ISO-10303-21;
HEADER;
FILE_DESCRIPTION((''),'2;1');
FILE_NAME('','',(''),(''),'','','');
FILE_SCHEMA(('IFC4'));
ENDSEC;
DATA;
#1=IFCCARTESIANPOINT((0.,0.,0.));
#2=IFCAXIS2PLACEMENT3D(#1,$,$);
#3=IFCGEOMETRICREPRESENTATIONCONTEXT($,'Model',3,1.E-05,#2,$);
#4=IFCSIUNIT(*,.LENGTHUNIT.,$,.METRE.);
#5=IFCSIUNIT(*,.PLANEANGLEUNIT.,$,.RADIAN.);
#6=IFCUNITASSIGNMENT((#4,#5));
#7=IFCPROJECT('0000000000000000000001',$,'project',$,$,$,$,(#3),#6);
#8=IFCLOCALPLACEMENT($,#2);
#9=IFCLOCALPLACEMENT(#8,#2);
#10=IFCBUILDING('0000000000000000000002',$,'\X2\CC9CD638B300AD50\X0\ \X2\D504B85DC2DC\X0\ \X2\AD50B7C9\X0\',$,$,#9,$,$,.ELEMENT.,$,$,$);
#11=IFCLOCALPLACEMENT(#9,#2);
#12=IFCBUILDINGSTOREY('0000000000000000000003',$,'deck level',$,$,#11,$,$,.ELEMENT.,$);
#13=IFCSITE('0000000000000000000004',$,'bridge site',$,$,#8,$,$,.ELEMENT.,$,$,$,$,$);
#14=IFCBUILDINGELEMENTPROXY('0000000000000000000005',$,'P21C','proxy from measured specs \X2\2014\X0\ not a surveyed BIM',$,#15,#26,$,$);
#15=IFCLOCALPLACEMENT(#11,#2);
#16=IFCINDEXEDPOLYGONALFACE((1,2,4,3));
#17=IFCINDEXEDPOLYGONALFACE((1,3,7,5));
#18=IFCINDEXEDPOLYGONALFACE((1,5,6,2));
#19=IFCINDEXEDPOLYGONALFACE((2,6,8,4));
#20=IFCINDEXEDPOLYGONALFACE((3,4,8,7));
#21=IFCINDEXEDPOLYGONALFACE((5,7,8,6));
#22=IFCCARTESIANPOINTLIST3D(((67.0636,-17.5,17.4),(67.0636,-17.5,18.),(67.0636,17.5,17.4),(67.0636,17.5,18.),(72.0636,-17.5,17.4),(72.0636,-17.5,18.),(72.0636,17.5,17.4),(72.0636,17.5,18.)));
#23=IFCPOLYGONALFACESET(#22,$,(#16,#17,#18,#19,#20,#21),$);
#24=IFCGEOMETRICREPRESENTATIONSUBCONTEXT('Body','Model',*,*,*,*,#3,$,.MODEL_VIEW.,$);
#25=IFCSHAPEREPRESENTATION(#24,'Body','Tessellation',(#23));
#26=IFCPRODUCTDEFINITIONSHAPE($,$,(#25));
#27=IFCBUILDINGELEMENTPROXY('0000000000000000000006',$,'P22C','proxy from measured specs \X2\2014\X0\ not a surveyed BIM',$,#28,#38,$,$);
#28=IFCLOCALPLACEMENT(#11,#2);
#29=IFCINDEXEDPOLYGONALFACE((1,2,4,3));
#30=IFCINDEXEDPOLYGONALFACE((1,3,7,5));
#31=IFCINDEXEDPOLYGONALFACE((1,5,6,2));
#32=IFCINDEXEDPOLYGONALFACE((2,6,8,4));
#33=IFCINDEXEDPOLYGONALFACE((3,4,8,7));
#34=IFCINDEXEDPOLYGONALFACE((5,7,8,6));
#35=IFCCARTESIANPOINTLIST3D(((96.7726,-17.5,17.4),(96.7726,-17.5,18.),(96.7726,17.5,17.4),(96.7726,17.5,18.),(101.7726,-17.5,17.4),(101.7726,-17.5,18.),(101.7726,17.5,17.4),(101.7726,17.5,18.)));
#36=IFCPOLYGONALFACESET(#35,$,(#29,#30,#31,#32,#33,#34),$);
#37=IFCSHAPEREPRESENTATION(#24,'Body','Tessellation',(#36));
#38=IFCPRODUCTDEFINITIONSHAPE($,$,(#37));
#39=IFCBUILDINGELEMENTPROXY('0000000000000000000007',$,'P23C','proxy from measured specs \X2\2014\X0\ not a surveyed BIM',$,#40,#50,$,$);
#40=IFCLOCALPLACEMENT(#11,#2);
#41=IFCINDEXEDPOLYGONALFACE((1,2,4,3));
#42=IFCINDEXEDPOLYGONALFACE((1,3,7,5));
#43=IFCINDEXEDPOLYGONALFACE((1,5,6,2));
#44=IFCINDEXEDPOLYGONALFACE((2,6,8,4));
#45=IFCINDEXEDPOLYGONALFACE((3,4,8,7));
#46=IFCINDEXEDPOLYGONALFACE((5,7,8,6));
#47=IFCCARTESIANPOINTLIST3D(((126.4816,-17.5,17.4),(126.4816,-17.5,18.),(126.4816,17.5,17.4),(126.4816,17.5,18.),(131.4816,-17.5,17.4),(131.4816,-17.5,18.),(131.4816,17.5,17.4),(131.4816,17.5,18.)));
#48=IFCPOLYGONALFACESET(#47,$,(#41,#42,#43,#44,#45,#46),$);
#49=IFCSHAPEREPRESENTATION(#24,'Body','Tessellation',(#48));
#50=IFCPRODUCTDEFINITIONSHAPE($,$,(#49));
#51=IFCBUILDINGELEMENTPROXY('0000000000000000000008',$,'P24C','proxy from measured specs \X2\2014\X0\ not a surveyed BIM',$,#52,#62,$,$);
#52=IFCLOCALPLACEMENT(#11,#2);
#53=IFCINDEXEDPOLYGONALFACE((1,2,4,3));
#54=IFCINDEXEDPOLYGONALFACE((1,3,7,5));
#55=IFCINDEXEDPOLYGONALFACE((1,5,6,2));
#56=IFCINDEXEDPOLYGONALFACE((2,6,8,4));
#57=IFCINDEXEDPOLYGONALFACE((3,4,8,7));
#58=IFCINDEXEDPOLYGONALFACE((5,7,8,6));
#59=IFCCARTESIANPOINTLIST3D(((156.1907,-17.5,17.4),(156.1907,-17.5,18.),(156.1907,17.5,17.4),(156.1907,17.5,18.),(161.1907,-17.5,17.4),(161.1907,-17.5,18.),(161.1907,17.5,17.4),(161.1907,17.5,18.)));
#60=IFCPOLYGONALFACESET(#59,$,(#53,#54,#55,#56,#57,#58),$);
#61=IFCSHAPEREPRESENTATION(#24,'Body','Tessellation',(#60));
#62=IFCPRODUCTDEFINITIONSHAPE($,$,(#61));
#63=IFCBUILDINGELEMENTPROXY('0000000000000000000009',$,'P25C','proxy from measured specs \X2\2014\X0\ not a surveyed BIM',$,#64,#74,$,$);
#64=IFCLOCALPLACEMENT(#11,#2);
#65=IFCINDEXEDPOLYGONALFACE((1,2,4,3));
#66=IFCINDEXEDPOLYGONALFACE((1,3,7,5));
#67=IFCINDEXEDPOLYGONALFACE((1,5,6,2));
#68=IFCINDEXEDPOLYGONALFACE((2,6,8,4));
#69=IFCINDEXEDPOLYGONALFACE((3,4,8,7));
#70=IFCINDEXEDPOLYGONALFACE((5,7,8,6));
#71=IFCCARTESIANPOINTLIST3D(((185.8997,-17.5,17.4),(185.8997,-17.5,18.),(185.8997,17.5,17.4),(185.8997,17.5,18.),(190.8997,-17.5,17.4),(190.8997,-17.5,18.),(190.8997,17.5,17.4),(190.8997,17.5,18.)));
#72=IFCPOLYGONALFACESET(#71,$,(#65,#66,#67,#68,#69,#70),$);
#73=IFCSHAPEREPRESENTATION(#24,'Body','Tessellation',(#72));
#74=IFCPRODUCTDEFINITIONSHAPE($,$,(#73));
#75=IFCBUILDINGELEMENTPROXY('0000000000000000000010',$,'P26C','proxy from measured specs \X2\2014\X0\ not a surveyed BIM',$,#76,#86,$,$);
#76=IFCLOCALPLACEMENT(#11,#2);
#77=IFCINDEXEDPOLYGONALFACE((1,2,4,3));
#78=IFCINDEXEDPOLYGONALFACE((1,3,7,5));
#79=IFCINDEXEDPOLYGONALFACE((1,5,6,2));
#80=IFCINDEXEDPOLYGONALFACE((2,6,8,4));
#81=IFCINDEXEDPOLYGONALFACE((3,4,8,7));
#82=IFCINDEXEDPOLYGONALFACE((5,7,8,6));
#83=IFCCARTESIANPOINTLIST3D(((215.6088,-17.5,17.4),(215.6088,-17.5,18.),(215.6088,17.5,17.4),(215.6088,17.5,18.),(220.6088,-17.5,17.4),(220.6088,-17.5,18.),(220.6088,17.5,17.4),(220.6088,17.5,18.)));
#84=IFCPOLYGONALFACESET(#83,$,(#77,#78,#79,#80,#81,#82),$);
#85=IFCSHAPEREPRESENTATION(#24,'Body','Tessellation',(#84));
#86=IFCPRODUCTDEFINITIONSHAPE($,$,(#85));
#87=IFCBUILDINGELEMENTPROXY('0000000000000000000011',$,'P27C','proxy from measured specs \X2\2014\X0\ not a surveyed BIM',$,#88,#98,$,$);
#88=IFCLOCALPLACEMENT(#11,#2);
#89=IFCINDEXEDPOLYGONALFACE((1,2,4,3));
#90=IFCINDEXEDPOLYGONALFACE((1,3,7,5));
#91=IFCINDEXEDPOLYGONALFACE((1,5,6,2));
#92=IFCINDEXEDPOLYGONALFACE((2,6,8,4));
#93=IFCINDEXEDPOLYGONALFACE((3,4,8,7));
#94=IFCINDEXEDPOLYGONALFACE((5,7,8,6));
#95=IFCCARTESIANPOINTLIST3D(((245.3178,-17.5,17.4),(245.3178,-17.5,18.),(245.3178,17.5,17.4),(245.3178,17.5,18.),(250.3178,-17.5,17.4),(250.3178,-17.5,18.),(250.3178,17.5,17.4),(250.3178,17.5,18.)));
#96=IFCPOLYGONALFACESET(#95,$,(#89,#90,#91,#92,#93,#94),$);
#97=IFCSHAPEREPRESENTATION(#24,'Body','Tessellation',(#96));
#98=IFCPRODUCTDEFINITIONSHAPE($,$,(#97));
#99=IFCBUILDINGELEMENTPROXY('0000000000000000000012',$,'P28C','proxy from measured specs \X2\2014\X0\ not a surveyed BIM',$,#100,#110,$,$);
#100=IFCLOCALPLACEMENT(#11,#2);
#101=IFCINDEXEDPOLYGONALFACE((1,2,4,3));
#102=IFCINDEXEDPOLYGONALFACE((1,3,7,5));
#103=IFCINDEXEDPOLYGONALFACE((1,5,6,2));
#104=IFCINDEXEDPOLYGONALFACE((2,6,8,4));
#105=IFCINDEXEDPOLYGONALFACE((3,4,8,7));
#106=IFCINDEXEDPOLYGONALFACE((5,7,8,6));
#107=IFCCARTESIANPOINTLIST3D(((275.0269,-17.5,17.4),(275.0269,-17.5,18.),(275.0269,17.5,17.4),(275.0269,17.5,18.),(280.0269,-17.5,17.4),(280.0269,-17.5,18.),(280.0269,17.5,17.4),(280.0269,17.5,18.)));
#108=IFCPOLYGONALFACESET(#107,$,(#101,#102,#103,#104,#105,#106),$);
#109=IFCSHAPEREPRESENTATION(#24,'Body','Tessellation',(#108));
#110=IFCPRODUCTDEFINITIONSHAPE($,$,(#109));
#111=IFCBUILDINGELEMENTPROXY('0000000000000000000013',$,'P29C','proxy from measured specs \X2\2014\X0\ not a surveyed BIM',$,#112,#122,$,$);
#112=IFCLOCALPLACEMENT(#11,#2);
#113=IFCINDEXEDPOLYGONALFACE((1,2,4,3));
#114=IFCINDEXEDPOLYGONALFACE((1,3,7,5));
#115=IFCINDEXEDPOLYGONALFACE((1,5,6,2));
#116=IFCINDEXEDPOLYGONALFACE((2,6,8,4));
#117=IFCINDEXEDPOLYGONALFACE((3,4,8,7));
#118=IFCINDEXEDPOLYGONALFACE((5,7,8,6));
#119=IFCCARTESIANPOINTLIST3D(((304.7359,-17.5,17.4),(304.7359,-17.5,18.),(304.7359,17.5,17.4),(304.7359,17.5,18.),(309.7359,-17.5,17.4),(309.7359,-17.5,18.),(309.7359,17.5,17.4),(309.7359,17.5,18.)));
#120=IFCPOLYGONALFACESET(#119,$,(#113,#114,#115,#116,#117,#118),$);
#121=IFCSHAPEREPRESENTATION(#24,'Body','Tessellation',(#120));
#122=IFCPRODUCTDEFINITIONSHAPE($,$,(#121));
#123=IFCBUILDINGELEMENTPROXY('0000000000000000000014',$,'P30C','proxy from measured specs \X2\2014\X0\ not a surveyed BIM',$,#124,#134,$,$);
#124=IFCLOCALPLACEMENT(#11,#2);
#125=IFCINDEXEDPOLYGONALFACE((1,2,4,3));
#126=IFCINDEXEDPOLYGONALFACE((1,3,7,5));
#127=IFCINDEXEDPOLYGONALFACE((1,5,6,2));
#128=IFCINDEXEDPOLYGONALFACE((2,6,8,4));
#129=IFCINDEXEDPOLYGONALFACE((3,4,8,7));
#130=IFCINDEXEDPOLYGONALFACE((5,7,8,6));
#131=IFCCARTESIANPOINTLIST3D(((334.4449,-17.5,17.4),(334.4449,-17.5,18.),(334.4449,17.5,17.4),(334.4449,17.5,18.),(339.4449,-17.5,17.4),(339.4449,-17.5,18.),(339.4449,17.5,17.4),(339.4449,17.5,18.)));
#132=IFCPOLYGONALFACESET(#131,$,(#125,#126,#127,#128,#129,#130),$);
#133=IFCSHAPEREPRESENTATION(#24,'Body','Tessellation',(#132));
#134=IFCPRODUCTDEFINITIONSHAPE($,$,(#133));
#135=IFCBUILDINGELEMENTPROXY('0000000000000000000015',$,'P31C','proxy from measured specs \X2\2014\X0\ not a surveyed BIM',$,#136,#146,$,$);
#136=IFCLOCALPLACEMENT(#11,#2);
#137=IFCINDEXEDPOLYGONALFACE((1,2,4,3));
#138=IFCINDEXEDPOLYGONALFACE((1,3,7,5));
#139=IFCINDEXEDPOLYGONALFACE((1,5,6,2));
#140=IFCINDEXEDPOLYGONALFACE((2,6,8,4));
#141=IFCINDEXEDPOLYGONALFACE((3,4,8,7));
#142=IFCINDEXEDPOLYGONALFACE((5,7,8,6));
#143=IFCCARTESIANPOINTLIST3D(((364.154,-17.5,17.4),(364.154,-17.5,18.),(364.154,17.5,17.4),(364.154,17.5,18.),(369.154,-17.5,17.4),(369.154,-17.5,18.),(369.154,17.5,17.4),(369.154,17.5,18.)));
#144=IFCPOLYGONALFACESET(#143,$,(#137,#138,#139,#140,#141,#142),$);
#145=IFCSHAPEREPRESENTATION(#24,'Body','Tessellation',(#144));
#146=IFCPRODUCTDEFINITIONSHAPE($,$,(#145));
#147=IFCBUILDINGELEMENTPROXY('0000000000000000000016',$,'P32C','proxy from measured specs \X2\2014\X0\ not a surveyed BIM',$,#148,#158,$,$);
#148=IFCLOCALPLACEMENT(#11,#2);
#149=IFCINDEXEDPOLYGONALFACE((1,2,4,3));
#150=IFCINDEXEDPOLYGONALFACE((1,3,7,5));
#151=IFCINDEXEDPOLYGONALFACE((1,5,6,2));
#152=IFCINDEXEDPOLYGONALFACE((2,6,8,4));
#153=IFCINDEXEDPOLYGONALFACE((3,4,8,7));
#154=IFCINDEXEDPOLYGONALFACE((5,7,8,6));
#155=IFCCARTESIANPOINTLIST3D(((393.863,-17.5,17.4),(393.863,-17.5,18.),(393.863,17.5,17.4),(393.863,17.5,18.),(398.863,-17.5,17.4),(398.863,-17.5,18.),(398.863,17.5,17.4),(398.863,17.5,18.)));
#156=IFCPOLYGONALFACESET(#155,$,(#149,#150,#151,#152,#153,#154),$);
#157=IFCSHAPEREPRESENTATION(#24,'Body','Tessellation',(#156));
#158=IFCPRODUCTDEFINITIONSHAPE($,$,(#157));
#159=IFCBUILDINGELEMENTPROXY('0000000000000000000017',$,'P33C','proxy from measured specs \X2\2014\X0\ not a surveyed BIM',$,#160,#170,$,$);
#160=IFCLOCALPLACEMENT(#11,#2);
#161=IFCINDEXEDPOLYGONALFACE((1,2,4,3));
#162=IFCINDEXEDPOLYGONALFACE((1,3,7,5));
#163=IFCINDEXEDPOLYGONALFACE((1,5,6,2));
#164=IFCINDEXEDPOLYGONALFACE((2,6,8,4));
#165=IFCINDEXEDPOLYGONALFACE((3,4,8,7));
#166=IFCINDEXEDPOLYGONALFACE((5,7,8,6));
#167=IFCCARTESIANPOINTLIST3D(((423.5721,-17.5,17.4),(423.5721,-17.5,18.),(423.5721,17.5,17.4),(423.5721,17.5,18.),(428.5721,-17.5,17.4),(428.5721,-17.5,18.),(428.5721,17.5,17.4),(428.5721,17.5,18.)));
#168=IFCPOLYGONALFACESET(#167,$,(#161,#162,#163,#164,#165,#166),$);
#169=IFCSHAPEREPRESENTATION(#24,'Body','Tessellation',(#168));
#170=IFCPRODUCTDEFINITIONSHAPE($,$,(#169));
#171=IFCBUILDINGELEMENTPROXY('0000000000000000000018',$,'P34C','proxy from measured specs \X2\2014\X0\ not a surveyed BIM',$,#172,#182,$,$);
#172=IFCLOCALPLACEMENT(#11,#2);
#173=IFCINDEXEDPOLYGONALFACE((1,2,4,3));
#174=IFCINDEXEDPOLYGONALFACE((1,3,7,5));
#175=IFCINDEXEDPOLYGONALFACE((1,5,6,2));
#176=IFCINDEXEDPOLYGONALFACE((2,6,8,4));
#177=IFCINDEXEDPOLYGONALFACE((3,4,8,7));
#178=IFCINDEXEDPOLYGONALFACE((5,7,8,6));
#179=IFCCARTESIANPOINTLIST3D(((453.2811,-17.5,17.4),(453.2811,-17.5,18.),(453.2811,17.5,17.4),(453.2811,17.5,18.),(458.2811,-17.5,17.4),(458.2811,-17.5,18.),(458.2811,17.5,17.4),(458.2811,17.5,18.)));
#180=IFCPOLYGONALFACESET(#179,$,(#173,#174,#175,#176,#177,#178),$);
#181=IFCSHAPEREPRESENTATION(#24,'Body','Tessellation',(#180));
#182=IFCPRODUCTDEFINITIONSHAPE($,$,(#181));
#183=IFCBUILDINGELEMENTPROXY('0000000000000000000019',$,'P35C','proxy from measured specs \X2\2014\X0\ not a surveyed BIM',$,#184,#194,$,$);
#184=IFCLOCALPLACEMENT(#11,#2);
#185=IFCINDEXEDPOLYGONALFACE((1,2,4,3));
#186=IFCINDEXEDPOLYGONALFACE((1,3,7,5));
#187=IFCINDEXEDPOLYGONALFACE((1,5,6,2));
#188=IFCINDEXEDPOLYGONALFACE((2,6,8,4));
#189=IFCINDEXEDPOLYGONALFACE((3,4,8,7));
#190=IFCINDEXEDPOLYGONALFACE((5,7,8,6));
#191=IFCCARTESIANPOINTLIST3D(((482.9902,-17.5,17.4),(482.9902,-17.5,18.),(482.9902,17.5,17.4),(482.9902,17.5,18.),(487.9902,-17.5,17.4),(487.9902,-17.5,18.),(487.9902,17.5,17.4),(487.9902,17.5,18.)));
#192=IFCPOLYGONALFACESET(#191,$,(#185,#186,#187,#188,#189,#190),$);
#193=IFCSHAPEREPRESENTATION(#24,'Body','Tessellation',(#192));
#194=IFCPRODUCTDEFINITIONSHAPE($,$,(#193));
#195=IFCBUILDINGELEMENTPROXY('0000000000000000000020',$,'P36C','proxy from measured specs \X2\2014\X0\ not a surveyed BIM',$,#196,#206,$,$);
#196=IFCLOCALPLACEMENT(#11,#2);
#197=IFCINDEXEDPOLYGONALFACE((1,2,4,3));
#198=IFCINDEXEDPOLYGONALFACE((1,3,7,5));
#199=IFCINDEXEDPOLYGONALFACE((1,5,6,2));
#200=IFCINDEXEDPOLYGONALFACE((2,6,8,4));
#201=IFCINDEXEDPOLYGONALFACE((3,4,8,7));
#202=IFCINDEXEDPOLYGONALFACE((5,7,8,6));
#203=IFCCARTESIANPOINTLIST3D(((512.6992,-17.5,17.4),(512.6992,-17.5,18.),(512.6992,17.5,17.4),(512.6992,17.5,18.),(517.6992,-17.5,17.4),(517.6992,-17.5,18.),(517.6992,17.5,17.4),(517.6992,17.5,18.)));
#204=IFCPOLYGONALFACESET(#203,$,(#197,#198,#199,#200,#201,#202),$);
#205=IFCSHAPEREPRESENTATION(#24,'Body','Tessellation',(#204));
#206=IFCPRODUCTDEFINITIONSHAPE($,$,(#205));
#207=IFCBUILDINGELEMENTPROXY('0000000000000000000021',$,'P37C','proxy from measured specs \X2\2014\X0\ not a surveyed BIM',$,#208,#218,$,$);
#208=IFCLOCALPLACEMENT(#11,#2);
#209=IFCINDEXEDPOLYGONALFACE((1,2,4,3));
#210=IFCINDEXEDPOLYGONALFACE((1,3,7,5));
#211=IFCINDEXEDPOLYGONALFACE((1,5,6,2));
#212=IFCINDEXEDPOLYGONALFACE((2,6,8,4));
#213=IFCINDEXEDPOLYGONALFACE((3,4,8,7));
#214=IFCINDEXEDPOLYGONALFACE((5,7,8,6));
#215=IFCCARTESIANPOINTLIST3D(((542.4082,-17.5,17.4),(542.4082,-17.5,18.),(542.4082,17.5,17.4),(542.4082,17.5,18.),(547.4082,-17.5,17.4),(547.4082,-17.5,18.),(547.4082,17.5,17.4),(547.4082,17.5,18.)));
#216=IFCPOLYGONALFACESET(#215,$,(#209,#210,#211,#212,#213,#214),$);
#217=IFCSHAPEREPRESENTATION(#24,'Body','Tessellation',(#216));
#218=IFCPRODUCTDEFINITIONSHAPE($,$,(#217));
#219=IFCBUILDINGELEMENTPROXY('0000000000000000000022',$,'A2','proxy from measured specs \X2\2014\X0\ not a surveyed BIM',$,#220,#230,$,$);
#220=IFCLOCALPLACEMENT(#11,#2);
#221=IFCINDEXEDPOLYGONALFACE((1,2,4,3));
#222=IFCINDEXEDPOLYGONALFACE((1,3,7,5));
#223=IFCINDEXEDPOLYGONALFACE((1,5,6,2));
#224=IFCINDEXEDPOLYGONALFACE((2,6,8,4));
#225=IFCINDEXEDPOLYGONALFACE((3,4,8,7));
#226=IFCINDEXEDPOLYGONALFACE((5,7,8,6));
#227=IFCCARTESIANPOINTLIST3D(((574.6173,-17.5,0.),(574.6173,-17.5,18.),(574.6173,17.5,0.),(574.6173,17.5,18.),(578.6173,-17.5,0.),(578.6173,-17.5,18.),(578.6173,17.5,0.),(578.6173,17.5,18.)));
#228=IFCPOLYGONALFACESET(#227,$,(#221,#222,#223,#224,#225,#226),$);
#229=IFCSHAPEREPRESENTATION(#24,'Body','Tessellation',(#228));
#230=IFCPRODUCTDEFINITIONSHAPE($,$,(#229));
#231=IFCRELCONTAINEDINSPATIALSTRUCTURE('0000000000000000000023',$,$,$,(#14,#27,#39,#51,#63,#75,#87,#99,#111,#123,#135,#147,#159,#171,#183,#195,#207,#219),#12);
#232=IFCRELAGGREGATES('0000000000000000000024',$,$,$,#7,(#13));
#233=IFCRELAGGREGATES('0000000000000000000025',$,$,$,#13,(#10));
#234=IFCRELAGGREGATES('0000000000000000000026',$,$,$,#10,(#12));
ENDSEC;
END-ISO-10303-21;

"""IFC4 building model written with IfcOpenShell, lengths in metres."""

from ifc_helpers import new_model, si_unit, frame, origin, origin_2d, place, context, subcontext, project, spatial, rectangle, extrude, element, save


model = new_model("IFC4")

# Units and contexts
model_context = context("Model", 3, precision=1e-05, world=origin())
body_context = subcontext(model_context, "Body", "Model", "MODEL_VIEW")
ifc_project = project(units=[si_unit("LENGTHUNIT", "METRE"), si_unit("PLANEANGLEUNIT", "RADIAN")], contexts=[model_context])

# Site, building, storey
site_placement = place(None, origin())
site = spatial("IfcSite", under=ifc_project, at=site_placement, Name="bridge site", CompositionType="ELEMENT")
building_placement = place(site_placement, origin())
building = spatial("IfcBuilding", under=site, at=building_placement, Name="천호대교 프록시 교량", CompositionType="ELEMENT")
storey_placement = place(building_placement, origin())
storey = spatial("IfcBuildingStorey", under=building, at=storey_placement, Name="deck level", CompositionType="ELEMENT")

# Building element proxies
for number, where, name in (
    (1, (69.5636, 0.0, 17.4), "P21C"),
    (2, (99.2726, 0.0, 17.4), "P22C"),
    (3, (128.9816, 0.0, 17.4), "P23C"),
    (4, (158.6907, 0.0, 17.4), "P24C"),
    (5, (188.3997, 0.0, 17.4), "P25C"),
    (6, (218.1088, 0.0, 17.4), "P26C"),
    (7, (247.8178, 0.0, 17.4), "P27C"),
    (8, (277.5269, 0.0, 17.4), "P28C"),
    (9, (307.2359, 0.0, 17.4), "P29C"),
    (10, (336.9449, 0.0, 17.4), "P30C"),
    (11, (366.654, 0.0, 17.4), "P31C"),
    (12, (396.363, 0.0, 17.4), "P32C"),
    (13, (426.0721, 0.0, 17.4), "P33C"),
    (14, (455.7811, 0.0, 17.4), "P34C"),
    (15, (485.4902, 0.0, 17.4), "P35C"),
    (16, (515.1992, 0.0, 17.4), "P36C"),
    (17, (544.9082, 0.0, 17.4), "P37C"),
):
    element("IfcBuildingElementProxy", number, at=place(storey_placement, frame(where)), inside=storey, Name=name, Description="proxy from measured specs — not a surveyed BIM", context=body_context, shape_type="SweptSolid", body=[
        extrude(rectangle(XDim=5.0, YDim=35.0, at=origin_2d()), origin(), (0.0, 0.0, 1.0), 0.6),
    ])
proxy_placement = place(storey_placement, frame((576.6173, 0.0, 0.0)))
element("IfcBuildingElementProxy", 18, at=proxy_placement, inside=storey, Name="A2", Description="proxy from measured specs — not a surveyed BIM", context=body_context, shape_type="SweptSolid", body=[
    extrude(rectangle(XDim=4.0, YDim=35.0, at=origin_2d()), origin(), (0.0, 0.0, 1.0), 18.0),
])

save(model, "model.ifc")
